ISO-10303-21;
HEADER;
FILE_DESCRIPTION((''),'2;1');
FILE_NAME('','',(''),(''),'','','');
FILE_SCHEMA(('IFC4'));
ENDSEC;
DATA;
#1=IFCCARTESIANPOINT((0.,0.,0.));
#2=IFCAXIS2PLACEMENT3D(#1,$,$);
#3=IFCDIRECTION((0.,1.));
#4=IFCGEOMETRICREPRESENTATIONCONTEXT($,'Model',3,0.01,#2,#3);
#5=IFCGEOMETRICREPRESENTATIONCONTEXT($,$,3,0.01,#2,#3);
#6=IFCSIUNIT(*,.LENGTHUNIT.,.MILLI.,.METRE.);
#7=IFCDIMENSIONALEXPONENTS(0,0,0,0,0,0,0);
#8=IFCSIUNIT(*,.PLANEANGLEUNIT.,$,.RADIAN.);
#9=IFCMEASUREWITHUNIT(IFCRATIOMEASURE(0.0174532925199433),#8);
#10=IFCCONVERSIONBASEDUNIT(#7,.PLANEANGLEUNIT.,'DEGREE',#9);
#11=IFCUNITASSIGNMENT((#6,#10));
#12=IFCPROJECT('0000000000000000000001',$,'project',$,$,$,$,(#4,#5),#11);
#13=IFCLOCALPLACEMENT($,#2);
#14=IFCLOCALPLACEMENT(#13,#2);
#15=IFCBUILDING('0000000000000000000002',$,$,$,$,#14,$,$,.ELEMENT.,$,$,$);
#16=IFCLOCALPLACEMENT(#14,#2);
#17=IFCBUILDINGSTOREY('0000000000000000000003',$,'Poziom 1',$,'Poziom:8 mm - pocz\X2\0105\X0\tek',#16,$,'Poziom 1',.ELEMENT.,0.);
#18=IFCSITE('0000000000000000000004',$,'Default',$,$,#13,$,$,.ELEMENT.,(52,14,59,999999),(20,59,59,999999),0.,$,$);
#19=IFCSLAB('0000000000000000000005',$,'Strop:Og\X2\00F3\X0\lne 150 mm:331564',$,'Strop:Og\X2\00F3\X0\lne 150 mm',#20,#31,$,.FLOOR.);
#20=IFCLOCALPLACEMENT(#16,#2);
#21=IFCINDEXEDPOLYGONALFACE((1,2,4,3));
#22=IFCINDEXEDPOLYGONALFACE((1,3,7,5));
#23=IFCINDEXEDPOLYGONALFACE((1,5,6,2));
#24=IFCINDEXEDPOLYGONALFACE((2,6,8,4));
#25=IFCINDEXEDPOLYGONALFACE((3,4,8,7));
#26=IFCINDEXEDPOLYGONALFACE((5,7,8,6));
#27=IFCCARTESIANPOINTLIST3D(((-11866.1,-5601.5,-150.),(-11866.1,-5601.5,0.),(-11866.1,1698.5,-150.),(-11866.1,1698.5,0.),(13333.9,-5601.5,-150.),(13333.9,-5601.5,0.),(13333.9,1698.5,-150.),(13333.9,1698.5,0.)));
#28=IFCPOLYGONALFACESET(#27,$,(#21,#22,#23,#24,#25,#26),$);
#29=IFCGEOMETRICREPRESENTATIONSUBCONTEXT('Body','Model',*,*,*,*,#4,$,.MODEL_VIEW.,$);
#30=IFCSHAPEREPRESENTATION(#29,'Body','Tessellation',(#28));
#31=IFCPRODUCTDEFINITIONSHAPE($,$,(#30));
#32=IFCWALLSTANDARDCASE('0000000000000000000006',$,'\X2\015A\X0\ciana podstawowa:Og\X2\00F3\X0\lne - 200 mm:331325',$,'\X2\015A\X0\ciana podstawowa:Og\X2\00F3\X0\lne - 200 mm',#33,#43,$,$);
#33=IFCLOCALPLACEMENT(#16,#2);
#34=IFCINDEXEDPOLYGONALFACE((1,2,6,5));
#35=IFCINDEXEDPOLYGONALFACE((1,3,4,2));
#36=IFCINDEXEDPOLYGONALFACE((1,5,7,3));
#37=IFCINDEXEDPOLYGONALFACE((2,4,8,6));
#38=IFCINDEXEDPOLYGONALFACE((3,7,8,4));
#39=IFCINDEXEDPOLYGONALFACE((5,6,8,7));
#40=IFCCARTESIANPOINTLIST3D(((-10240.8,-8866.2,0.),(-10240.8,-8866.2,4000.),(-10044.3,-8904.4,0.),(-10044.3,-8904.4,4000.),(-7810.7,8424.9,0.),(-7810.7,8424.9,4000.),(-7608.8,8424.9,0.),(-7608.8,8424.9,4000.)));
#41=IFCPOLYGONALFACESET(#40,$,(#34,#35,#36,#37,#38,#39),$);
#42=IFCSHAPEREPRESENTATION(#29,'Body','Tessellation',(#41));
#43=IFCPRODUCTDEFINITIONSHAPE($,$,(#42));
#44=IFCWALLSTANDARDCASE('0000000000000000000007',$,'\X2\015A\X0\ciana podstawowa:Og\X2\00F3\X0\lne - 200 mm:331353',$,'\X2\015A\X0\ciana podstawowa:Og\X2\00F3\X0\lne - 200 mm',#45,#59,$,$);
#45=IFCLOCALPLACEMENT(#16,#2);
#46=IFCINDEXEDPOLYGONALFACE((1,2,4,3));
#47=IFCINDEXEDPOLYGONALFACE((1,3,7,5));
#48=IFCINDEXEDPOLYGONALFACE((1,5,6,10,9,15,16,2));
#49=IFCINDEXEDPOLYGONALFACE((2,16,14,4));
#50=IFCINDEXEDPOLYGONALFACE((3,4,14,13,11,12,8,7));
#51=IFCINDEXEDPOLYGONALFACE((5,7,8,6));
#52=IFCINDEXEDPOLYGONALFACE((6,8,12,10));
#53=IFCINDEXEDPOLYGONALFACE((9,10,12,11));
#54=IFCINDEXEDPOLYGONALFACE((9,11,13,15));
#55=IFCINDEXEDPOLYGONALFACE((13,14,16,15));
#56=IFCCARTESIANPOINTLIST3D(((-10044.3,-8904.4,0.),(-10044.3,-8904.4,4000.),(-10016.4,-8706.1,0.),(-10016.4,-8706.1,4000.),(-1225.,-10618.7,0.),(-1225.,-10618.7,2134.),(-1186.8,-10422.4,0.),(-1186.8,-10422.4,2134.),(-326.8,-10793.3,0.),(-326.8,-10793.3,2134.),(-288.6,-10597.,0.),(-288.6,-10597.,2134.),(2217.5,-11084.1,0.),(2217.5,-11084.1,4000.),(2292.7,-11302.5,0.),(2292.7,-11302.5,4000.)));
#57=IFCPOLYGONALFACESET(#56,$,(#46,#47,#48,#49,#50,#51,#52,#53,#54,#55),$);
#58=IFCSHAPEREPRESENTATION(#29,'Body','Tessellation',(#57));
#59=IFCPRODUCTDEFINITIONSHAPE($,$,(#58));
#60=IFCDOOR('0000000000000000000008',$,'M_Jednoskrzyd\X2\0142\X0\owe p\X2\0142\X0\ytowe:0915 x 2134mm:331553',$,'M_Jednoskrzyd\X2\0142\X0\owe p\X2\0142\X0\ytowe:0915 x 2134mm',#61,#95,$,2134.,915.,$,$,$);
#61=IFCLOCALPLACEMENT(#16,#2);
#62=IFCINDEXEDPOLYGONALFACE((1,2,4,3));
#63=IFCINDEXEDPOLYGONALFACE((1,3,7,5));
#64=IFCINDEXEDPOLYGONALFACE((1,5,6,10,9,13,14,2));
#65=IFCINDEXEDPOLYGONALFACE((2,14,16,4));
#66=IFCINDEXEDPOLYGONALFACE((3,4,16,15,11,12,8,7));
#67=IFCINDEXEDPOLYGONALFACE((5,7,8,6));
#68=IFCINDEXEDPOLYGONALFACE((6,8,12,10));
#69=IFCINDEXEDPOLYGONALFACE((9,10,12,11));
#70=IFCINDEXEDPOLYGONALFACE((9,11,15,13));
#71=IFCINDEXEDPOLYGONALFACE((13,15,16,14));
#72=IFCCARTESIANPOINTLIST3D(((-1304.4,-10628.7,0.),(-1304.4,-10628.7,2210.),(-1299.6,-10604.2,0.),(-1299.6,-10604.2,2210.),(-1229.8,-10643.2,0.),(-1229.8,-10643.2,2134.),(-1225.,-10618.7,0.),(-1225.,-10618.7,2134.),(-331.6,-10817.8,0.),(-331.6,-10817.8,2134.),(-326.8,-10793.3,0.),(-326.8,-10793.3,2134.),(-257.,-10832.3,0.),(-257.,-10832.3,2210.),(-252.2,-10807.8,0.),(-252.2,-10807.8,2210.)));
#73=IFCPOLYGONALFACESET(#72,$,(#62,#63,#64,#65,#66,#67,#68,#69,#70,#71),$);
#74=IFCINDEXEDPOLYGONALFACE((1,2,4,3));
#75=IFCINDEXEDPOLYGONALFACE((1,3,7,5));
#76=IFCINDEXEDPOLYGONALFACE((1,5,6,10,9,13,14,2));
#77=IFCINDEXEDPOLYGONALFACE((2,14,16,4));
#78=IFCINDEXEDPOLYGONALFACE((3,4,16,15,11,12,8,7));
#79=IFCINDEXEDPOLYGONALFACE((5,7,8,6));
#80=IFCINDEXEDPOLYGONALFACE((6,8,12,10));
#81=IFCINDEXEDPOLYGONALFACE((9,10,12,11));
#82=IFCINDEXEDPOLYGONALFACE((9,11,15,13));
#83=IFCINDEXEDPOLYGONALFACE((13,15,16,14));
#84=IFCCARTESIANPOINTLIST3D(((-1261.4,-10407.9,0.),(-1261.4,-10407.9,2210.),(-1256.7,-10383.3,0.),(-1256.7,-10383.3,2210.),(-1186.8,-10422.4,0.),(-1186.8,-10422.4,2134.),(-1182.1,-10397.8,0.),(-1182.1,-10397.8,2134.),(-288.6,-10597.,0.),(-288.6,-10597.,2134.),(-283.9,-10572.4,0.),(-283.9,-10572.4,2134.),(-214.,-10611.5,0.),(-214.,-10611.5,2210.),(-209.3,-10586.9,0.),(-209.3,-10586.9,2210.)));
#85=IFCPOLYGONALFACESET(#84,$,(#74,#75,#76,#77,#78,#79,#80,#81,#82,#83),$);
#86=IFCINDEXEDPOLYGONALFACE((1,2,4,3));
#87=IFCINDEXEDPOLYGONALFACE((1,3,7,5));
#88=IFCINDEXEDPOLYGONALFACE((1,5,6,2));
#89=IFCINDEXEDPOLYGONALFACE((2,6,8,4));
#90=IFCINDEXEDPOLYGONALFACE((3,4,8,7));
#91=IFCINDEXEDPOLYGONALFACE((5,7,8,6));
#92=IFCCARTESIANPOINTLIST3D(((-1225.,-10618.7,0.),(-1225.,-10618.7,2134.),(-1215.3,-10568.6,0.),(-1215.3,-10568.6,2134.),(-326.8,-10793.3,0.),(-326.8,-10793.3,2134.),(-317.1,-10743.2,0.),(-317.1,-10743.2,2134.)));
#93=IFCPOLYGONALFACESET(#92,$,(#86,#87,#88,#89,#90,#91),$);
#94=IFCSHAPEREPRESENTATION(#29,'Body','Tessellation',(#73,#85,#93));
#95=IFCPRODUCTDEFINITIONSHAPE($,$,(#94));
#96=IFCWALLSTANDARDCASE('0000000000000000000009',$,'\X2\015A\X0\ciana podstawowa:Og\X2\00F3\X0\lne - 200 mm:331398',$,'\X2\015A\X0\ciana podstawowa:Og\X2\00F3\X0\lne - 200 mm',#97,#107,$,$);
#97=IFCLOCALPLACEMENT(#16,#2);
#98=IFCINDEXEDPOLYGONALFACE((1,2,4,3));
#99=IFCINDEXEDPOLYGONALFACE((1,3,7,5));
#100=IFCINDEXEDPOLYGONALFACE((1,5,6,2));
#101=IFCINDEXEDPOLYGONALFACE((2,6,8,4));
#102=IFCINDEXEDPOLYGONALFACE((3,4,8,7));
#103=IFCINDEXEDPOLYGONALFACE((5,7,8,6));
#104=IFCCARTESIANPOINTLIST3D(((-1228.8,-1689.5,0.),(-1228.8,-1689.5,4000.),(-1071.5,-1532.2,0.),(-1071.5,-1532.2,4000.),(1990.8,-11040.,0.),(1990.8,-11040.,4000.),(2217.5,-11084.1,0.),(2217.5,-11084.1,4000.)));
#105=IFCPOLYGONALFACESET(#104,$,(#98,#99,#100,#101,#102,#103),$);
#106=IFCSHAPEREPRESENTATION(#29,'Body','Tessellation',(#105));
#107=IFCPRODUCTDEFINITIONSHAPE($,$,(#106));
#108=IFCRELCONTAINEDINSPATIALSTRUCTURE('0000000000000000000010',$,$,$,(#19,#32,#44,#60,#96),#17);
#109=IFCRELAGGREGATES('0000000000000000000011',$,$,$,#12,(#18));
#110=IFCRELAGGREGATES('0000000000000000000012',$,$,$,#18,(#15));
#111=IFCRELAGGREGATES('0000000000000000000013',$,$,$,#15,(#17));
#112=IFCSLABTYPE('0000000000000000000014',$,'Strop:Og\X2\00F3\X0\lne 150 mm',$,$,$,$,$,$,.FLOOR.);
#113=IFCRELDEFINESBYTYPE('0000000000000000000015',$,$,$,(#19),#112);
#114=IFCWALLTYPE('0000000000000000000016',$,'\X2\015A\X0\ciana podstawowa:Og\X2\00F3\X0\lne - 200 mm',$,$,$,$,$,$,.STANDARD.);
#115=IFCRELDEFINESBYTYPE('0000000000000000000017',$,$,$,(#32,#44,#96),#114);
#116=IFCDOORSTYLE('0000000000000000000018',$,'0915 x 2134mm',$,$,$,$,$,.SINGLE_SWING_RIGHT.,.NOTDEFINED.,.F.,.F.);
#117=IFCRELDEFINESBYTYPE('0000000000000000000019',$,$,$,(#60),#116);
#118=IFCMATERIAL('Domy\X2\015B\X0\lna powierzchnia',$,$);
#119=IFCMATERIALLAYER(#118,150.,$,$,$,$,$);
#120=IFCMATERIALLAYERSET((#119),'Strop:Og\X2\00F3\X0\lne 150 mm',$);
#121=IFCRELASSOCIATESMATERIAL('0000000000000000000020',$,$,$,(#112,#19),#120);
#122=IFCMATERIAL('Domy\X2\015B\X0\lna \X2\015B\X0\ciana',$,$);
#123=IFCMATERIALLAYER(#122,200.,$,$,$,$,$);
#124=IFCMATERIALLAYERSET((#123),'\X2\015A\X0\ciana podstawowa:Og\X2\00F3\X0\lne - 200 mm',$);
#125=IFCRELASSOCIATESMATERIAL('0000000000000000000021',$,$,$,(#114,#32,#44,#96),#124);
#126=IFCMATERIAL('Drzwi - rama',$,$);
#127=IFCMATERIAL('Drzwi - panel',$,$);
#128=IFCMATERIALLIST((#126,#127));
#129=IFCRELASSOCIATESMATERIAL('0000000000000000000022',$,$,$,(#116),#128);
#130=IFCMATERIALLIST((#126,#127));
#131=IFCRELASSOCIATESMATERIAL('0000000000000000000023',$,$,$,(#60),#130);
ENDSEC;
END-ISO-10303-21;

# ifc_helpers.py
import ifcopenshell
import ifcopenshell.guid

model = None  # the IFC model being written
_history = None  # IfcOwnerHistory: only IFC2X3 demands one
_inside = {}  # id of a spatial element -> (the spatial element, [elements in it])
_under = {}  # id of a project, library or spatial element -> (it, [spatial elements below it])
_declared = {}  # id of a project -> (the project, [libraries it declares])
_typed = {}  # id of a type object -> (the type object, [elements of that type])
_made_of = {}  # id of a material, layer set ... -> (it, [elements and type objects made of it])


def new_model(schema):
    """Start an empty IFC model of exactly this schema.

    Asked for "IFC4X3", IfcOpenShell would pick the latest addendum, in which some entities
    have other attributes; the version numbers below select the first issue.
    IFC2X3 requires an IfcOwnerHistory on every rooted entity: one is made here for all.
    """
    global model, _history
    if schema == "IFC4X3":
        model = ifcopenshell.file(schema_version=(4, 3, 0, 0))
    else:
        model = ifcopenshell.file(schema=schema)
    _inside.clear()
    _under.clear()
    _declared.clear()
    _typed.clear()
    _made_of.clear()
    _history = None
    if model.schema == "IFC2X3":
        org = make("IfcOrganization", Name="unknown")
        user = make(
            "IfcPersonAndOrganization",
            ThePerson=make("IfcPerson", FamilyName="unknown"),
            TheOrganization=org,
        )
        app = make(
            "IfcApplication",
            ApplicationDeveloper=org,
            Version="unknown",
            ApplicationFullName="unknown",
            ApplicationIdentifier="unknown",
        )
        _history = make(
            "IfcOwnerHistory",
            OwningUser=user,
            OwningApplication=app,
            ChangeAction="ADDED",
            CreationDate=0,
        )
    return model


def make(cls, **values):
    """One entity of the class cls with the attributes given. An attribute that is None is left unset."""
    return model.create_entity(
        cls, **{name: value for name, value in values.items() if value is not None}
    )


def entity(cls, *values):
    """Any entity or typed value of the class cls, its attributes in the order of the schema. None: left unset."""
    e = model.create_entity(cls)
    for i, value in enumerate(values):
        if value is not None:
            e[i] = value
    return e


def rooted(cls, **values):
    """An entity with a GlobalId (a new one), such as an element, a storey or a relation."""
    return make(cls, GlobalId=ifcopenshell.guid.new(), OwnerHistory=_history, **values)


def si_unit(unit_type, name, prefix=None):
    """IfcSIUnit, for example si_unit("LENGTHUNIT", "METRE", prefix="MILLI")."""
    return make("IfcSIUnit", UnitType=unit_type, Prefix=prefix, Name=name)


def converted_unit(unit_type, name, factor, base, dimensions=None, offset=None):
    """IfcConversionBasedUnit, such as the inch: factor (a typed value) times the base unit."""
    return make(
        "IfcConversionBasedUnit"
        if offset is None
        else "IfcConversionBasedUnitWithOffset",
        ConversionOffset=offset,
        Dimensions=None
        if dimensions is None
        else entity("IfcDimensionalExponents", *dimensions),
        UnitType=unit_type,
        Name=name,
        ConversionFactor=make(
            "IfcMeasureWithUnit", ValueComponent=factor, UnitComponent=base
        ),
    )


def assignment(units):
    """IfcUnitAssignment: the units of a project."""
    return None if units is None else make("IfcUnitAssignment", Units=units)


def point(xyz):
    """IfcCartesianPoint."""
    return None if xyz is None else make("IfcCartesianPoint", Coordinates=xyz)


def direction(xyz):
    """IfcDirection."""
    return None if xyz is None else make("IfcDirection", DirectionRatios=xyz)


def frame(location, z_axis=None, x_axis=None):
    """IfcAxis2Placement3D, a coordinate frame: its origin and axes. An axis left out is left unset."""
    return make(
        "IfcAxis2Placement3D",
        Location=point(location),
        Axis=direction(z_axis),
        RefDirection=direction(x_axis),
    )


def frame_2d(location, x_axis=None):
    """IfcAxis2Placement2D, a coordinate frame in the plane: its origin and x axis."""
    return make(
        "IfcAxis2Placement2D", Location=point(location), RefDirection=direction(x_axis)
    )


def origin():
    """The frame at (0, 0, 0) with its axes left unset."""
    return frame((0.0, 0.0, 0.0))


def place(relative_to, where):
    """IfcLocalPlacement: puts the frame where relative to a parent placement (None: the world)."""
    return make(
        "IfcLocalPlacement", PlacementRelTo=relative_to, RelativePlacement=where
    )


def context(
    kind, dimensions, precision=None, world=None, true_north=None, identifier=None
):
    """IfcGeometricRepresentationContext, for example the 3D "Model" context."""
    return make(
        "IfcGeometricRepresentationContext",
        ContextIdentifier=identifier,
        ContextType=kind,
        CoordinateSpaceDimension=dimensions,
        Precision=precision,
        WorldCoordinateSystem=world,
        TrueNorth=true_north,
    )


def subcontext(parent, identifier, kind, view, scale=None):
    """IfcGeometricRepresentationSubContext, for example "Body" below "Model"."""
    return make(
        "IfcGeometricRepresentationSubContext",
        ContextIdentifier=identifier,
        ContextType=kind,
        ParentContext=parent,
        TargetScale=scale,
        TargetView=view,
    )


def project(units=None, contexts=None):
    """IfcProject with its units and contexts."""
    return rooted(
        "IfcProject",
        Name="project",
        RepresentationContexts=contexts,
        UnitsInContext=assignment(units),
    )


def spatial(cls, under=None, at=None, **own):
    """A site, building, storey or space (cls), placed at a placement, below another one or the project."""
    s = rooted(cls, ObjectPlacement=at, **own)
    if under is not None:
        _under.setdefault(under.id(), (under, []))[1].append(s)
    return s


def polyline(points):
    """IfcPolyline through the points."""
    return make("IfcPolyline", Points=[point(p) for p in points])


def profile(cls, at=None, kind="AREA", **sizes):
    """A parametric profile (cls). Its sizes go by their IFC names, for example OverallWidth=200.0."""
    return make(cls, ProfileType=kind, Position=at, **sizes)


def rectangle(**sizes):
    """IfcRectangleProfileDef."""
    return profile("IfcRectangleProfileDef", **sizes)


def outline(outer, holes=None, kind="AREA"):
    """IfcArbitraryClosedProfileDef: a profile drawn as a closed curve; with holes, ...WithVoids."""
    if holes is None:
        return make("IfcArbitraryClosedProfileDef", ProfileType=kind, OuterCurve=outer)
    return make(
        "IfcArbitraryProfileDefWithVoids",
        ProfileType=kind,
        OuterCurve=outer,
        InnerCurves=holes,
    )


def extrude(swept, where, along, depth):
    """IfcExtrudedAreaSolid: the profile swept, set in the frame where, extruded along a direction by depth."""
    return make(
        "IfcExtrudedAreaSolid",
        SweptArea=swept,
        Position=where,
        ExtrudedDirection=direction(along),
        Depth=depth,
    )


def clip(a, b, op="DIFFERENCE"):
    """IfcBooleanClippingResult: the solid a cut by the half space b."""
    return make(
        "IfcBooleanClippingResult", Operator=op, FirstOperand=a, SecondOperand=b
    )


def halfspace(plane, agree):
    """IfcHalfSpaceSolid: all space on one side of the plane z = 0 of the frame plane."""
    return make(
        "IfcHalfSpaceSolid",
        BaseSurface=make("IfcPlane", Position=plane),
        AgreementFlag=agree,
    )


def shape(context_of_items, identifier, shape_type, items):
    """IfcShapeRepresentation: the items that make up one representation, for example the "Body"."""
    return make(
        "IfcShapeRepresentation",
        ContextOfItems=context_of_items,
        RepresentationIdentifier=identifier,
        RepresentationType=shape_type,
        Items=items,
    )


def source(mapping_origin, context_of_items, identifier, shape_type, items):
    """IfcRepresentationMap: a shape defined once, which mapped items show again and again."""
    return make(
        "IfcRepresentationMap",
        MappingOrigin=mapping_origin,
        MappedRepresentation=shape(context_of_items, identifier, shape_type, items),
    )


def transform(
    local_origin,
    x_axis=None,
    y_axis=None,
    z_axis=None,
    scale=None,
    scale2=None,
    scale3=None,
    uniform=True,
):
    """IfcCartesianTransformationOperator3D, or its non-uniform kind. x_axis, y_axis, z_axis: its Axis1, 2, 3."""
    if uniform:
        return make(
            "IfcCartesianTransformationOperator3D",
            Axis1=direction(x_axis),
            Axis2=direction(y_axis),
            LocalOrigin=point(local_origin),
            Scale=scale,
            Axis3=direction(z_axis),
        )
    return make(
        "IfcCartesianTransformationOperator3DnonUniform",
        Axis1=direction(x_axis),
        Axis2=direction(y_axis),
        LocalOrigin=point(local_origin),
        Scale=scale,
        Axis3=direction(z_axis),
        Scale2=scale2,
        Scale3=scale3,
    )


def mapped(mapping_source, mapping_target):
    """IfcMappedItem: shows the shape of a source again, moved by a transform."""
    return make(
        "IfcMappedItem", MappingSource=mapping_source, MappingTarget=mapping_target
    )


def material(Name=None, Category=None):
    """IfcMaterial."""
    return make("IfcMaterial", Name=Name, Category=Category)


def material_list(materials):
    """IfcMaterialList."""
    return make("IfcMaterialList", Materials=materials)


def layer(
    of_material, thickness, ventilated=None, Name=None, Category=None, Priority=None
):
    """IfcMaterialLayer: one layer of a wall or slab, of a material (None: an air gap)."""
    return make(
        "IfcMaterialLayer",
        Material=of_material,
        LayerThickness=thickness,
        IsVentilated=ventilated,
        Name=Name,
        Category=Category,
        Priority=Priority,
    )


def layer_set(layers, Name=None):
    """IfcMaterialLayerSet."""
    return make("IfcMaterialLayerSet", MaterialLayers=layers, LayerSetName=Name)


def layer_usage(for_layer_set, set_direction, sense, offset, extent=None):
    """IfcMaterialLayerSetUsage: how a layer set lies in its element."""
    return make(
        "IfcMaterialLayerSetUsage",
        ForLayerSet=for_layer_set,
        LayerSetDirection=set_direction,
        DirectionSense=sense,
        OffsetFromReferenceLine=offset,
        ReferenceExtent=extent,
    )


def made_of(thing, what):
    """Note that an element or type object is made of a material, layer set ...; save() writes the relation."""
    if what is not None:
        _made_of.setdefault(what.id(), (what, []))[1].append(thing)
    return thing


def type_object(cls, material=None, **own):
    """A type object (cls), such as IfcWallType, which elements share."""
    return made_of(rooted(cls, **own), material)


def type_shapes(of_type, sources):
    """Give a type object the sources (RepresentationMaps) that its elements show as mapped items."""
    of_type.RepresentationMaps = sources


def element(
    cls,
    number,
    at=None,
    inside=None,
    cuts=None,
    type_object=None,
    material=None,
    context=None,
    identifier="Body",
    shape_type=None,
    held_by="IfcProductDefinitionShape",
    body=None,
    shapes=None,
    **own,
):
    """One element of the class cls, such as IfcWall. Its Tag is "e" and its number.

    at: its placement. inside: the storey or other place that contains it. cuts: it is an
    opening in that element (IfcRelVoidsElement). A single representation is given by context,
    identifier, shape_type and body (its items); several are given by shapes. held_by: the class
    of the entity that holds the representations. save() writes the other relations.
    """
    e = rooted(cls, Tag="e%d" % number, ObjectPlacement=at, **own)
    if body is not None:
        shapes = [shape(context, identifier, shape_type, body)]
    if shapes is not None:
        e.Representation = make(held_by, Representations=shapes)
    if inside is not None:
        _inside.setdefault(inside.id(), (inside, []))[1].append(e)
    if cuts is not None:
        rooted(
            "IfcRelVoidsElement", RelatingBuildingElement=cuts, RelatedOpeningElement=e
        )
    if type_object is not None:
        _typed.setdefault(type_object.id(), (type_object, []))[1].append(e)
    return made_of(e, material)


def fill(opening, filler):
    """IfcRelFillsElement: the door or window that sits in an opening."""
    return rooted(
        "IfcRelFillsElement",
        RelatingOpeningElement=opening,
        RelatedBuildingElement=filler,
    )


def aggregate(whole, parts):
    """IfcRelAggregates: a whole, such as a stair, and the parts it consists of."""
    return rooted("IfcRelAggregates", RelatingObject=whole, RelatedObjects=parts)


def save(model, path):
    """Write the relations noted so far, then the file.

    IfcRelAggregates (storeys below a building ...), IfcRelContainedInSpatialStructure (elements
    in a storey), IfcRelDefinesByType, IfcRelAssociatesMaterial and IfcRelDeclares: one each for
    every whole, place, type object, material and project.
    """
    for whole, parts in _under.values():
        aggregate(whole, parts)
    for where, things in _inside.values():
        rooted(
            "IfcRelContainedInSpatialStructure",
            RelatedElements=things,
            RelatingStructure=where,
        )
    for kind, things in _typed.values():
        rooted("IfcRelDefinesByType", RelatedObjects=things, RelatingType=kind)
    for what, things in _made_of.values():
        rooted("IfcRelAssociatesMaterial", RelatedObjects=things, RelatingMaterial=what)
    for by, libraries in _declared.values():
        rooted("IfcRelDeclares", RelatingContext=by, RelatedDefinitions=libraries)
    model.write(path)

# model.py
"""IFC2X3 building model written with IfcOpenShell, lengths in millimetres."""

from ifc_helpers import new_model, entity, si_unit, converted_unit, direction, frame, frame_2d, origin, place, context, subcontext, project, spatial, polyline, rectangle, outline, extrude, clip, halfspace, source, transform, mapped, material, material_list, layer, layer_set, layer_usage, type_object, type_shapes, element, fill, save


model = new_model("IFC2X3")

# Units and contexts
model_context = context("Model", 3, precision=0.01, world=origin(), true_north=direction((0.0, 1.0)))
context_of_model = context(None, 3, precision=0.01, world=origin(), true_north=direction((0.0, 1.0)))
body_context = subcontext(model_context, "Body", "Model", "MODEL_VIEW")
ifc_project = project(units=[si_unit("LENGTHUNIT", "METRE", prefix="MILLI"), converted_unit("PLANEANGLEUNIT", "DEGREE", entity("IfcRatioMeasure", 0.0174532925199433), si_unit("PLANEANGLEUNIT", "RADIAN"), dimensions=[0, 0, 0, 0, 0, 0, 0])], contexts=[model_context, context_of_model])

# Site, building, storey
site_placement = place(None, origin())
site = spatial("IfcSite", under=ifc_project, at=site_placement, Name="Default", CompositionType="ELEMENT", RefLatitude=(52, 14, 59, 999999), RefLongitude=(20, 59, 59, 999999), RefElevation=0.0)
building_placement = place(site_placement, origin())
building = spatial("IfcBuilding", under=site, at=building_placement, CompositionType="ELEMENT")
storey_placement = place(building_placement, origin())
storey = spatial("IfcBuildingStorey", under=building, at=storey_placement, Name="Poziom 1", ObjectType="Poziom:8 mm - początek", LongName="Poziom 1", CompositionType="ELEMENT", Elevation=0.0)

# Slab
ifc_material_1 = material(Name="Domyślna powierzchnia")
ifc_layer_1 = layer(ifc_material_1, 150.0)
ifc_layer_set_1 = layer_set([ifc_layer_1], Name="Strop:Ogólne 150 mm")
ifc_layer_usage_1 = layer_usage(ifc_layer_set_1, "AXIS3", "POSITIVE", 0.0)
slab_type = type_object("IfcSlabType", Name="Strop:Ogólne 150 mm", PredefinedType="FLOOR", material=ifc_layer_set_1)
slab_placement = place(storey_placement, origin())
element("IfcSlab", 1, at=slab_placement, inside=storey, type_object=slab_type, material=ifc_layer_usage_1, Name="Strop:Ogólne 150 mm:331564", ObjectType="Strop:Ogólne 150 mm", PredefinedType="FLOOR", context=body_context, shape_type="SweptSolid", body=[
    extrude(rectangle(XDim=7300.0, YDim=25200.0, at=frame_2d((0.0, 0.0), x_axis=(1.0, 0.0))), frame((733.9, -1951.5, 0.0), z_axis=(0.0, 0.0, -1.0), x_axis=(0.0, 1.0, 0.0)), (0.0, 0.0, 1.0), 150.0),
])

# Wall
ifc_material_2 = material(Name="Domyślna ściana")
ifc_layer_2 = layer(ifc_material_2, 200.0)
ifc_layer_set_2 = layer_set([ifc_layer_2], Name="Ściana podstawowa:Ogólne - 200 mm")
ifc_layer_usage_2 = layer_usage(ifc_layer_set_2, "AXIS2", "NEGATIVE", 100.0)
wall_type = type_object("IfcWallType", Name="Ściana podstawowa:Ogólne - 200 mm", PredefinedType="STANDARD", material=ifc_layer_set_2)
wall_1_placement = place(storey_placement, frame((-7707.8, 8438.8, 0.0), z_axis=(0.0, 0.0, 1.0), x_axis=(-0.139173, -0.990268, 0.0)))
element("IfcWallStandardCase", 2, at=wall_1_placement, inside=storey, type_object=wall_type, material=ifc_layer_usage_2, Name="Ściana podstawowa:Ogólne - 200 mm:331325", ObjectType="Ściana podstawowa:Ogólne - 200 mm", context=body_context, shape_type="Clipping", body=[
    clip(extrude(outline(polyline([(17489.1, -100.0), (17499.6, 100.0), (17299.3, 100.0), (202.0, 100.0), (0.0, 100.0), (28.1, -100.0), (17489.1, -100.0)])), origin(), (0.0, 0.0, 1.0), 4000.0), halfspace(origin(), True)),
])

# Wall, opening, door
ifc_layer_usage_3 = layer_usage(ifc_layer_set_2, "AXIS2", "NEGATIVE", 100.0)
wall_2_placement = place(storey_placement, frame((-10035.5, -8804.2, 0.0), z_axis=(0.0, 0.0, 1.0), x_axis=(0.981627, -0.190809, 0.0)))
wall_2 = element("IfcWallStandardCase", 3, at=wall_2_placement, inside=storey, type_object=wall_type, material=ifc_layer_usage_3, Name="Ściana podstawowa:Ogólne - 200 mm:331353", ObjectType="Ściana podstawowa:Ogólne - 200 mm", context=body_context, shape_type="Clipping", body=[
    clip(extrude(outline(polyline([(10.5, -100.0), (12578.3, -100.0), (12462.8, 100.0), (12231.9, 100.0), (0.0, 100.0), (10.5, -100.0)])), origin(), (0.0, 0.0, 1.0), 4000.0), halfspace(origin(), True)),
])
opening_1_placement = place(wall_2_placement, frame((9909.8, 100.0, 0.0)))
opening_1 = element("IfcOpeningElement", 4, at=opening_1_placement, cuts=wall_2, ObjectType="Opening", context=body_context, shape_type="SweptSolid", body=[
    extrude(rectangle(XDim=915.0, YDim=2134.0, at=frame_2d((1067.0, 457.5), x_axis=(0.0, 1.0))), frame((0.0, 0.0, 0.0), z_axis=(0.0, -1.0, 0.0), x_axis=(0.0, 0.0, 1.0)), (0.0, 0.0, 1.0), 200.0),
])
ifc_material_3 = material(Name="Drzwi - rama")
ifc_material_4 = material(Name="Drzwi - panel")
ifc_material_list_1 = material_list([ifc_material_3, ifc_material_4])
ifc_material_list_2 = material_list([ifc_material_3, ifc_material_4])
door_style = type_object("IfcDoorStyle", Name="0915 x 2134mm", ConstructionType="NOTDEFINED", OperationType="SINGLE_SWING_RIGHT", ParameterTakesPrecedence=False, Sizeable=False, material=ifc_material_list_2)
shared_shape_1 = source(origin(), body_context, "Body", "SweptSolid", [
    extrude(outline(polyline([(-533.5, -1124.0), (533.5, -1124.0), (533.5, 1086.0), (457.5, 1086.0), (457.5, -1048.0), (-457.5, -1048.0), (-457.5, 1086.0), (-533.5, 1086.0), (-533.5, -1124.0)])), frame((457.5, 200.0, 1086.0), z_axis=(0.0, 1.0, 0.0), x_axis=(1.0, 0.0, 0.0)), (0.0, 0.0, 1.0), 25.0),
    extrude(outline(polyline([(-1124.0, -533.5), (1086.0, -533.5), (1086.0, -457.5), (-1048.0, -457.5), (-1048.0, 457.5), (1086.0, 457.5), (1086.0, 533.5), (-1124.0, 533.5), (-1124.0, -533.5)])), frame((457.5, -25.0, 1086.0), z_axis=(0.0, 1.0, 0.0), x_axis=(0.0, 0.0, -1.0)), (0.0, 0.0, 1.0), 25.0),
    extrude(rectangle(XDim=51.0, YDim=915.0, at=frame_2d((0.0, 0.0), x_axis=(1.0, 0.0))), frame((457.5, 174.5, 0.0), z_axis=(0.0, 0.0, 1.0), x_axis=(0.0, 1.0, 0.0)), (0.0, 0.0, 1.0), 2134.0),
])
type_shapes(door_style, [shared_shape_1])
door_placement = place(opening_1_placement, frame((0.0, 0.0, 0.0), z_axis=(0.0, 0.0, 1.0), x_axis=(-1.0, 0.0, 0.0)))
door = element("IfcDoor", 5, at=door_placement, inside=storey, type_object=door_style, material=ifc_material_list_1, Name="M_Jednoskrzydłowe płytowe:0915 x 2134mm:331553", ObjectType="M_Jednoskrzydłowe płytowe:0915 x 2134mm", OverallHeight=2134.0, OverallWidth=915.0, context=body_context, shape_type="MappedRepresentation", body=[
    mapped(shared_shape_1, transform((0.0, 0.0, 0.0), scale=1.0)),
])
fill(opening_1, door)

# Wall
ifc_layer_usage_4 = layer_usage(ifc_layer_set_2, "AXIS2", "NEGATIVE", 100.0)
wall_3_placement = place(storey_placement, frame((2122.9, -11116.7, 0.0), z_axis=(0.0, 0.0, 1.0), x_axis=(-0.325568, 0.945519, 0.0)))
element("IfcWallStandardCase", 6, at=wall_3_placement, inside=storey, type_object=wall_type, material=ifc_layer_usage_4, Name="Ściana podstawowa:Ogólne - 200 mm:331398", ObjectType="Ściana podstawowa:Ogólne - 200 mm", context=body_context, shape_type="Clipping", body=[
    clip(extrude(outline(polyline([(10102.3, -100.0), (10004.8, 100.0), (115.5, 100.0), (0.0, -100.0), (9879.8, -100.0), (10102.3, -100.0)])), origin(), (0.0, 0.0, 1.0), 4000.0), halfspace(origin(), True)),
])

save(model, "model.ifc")
